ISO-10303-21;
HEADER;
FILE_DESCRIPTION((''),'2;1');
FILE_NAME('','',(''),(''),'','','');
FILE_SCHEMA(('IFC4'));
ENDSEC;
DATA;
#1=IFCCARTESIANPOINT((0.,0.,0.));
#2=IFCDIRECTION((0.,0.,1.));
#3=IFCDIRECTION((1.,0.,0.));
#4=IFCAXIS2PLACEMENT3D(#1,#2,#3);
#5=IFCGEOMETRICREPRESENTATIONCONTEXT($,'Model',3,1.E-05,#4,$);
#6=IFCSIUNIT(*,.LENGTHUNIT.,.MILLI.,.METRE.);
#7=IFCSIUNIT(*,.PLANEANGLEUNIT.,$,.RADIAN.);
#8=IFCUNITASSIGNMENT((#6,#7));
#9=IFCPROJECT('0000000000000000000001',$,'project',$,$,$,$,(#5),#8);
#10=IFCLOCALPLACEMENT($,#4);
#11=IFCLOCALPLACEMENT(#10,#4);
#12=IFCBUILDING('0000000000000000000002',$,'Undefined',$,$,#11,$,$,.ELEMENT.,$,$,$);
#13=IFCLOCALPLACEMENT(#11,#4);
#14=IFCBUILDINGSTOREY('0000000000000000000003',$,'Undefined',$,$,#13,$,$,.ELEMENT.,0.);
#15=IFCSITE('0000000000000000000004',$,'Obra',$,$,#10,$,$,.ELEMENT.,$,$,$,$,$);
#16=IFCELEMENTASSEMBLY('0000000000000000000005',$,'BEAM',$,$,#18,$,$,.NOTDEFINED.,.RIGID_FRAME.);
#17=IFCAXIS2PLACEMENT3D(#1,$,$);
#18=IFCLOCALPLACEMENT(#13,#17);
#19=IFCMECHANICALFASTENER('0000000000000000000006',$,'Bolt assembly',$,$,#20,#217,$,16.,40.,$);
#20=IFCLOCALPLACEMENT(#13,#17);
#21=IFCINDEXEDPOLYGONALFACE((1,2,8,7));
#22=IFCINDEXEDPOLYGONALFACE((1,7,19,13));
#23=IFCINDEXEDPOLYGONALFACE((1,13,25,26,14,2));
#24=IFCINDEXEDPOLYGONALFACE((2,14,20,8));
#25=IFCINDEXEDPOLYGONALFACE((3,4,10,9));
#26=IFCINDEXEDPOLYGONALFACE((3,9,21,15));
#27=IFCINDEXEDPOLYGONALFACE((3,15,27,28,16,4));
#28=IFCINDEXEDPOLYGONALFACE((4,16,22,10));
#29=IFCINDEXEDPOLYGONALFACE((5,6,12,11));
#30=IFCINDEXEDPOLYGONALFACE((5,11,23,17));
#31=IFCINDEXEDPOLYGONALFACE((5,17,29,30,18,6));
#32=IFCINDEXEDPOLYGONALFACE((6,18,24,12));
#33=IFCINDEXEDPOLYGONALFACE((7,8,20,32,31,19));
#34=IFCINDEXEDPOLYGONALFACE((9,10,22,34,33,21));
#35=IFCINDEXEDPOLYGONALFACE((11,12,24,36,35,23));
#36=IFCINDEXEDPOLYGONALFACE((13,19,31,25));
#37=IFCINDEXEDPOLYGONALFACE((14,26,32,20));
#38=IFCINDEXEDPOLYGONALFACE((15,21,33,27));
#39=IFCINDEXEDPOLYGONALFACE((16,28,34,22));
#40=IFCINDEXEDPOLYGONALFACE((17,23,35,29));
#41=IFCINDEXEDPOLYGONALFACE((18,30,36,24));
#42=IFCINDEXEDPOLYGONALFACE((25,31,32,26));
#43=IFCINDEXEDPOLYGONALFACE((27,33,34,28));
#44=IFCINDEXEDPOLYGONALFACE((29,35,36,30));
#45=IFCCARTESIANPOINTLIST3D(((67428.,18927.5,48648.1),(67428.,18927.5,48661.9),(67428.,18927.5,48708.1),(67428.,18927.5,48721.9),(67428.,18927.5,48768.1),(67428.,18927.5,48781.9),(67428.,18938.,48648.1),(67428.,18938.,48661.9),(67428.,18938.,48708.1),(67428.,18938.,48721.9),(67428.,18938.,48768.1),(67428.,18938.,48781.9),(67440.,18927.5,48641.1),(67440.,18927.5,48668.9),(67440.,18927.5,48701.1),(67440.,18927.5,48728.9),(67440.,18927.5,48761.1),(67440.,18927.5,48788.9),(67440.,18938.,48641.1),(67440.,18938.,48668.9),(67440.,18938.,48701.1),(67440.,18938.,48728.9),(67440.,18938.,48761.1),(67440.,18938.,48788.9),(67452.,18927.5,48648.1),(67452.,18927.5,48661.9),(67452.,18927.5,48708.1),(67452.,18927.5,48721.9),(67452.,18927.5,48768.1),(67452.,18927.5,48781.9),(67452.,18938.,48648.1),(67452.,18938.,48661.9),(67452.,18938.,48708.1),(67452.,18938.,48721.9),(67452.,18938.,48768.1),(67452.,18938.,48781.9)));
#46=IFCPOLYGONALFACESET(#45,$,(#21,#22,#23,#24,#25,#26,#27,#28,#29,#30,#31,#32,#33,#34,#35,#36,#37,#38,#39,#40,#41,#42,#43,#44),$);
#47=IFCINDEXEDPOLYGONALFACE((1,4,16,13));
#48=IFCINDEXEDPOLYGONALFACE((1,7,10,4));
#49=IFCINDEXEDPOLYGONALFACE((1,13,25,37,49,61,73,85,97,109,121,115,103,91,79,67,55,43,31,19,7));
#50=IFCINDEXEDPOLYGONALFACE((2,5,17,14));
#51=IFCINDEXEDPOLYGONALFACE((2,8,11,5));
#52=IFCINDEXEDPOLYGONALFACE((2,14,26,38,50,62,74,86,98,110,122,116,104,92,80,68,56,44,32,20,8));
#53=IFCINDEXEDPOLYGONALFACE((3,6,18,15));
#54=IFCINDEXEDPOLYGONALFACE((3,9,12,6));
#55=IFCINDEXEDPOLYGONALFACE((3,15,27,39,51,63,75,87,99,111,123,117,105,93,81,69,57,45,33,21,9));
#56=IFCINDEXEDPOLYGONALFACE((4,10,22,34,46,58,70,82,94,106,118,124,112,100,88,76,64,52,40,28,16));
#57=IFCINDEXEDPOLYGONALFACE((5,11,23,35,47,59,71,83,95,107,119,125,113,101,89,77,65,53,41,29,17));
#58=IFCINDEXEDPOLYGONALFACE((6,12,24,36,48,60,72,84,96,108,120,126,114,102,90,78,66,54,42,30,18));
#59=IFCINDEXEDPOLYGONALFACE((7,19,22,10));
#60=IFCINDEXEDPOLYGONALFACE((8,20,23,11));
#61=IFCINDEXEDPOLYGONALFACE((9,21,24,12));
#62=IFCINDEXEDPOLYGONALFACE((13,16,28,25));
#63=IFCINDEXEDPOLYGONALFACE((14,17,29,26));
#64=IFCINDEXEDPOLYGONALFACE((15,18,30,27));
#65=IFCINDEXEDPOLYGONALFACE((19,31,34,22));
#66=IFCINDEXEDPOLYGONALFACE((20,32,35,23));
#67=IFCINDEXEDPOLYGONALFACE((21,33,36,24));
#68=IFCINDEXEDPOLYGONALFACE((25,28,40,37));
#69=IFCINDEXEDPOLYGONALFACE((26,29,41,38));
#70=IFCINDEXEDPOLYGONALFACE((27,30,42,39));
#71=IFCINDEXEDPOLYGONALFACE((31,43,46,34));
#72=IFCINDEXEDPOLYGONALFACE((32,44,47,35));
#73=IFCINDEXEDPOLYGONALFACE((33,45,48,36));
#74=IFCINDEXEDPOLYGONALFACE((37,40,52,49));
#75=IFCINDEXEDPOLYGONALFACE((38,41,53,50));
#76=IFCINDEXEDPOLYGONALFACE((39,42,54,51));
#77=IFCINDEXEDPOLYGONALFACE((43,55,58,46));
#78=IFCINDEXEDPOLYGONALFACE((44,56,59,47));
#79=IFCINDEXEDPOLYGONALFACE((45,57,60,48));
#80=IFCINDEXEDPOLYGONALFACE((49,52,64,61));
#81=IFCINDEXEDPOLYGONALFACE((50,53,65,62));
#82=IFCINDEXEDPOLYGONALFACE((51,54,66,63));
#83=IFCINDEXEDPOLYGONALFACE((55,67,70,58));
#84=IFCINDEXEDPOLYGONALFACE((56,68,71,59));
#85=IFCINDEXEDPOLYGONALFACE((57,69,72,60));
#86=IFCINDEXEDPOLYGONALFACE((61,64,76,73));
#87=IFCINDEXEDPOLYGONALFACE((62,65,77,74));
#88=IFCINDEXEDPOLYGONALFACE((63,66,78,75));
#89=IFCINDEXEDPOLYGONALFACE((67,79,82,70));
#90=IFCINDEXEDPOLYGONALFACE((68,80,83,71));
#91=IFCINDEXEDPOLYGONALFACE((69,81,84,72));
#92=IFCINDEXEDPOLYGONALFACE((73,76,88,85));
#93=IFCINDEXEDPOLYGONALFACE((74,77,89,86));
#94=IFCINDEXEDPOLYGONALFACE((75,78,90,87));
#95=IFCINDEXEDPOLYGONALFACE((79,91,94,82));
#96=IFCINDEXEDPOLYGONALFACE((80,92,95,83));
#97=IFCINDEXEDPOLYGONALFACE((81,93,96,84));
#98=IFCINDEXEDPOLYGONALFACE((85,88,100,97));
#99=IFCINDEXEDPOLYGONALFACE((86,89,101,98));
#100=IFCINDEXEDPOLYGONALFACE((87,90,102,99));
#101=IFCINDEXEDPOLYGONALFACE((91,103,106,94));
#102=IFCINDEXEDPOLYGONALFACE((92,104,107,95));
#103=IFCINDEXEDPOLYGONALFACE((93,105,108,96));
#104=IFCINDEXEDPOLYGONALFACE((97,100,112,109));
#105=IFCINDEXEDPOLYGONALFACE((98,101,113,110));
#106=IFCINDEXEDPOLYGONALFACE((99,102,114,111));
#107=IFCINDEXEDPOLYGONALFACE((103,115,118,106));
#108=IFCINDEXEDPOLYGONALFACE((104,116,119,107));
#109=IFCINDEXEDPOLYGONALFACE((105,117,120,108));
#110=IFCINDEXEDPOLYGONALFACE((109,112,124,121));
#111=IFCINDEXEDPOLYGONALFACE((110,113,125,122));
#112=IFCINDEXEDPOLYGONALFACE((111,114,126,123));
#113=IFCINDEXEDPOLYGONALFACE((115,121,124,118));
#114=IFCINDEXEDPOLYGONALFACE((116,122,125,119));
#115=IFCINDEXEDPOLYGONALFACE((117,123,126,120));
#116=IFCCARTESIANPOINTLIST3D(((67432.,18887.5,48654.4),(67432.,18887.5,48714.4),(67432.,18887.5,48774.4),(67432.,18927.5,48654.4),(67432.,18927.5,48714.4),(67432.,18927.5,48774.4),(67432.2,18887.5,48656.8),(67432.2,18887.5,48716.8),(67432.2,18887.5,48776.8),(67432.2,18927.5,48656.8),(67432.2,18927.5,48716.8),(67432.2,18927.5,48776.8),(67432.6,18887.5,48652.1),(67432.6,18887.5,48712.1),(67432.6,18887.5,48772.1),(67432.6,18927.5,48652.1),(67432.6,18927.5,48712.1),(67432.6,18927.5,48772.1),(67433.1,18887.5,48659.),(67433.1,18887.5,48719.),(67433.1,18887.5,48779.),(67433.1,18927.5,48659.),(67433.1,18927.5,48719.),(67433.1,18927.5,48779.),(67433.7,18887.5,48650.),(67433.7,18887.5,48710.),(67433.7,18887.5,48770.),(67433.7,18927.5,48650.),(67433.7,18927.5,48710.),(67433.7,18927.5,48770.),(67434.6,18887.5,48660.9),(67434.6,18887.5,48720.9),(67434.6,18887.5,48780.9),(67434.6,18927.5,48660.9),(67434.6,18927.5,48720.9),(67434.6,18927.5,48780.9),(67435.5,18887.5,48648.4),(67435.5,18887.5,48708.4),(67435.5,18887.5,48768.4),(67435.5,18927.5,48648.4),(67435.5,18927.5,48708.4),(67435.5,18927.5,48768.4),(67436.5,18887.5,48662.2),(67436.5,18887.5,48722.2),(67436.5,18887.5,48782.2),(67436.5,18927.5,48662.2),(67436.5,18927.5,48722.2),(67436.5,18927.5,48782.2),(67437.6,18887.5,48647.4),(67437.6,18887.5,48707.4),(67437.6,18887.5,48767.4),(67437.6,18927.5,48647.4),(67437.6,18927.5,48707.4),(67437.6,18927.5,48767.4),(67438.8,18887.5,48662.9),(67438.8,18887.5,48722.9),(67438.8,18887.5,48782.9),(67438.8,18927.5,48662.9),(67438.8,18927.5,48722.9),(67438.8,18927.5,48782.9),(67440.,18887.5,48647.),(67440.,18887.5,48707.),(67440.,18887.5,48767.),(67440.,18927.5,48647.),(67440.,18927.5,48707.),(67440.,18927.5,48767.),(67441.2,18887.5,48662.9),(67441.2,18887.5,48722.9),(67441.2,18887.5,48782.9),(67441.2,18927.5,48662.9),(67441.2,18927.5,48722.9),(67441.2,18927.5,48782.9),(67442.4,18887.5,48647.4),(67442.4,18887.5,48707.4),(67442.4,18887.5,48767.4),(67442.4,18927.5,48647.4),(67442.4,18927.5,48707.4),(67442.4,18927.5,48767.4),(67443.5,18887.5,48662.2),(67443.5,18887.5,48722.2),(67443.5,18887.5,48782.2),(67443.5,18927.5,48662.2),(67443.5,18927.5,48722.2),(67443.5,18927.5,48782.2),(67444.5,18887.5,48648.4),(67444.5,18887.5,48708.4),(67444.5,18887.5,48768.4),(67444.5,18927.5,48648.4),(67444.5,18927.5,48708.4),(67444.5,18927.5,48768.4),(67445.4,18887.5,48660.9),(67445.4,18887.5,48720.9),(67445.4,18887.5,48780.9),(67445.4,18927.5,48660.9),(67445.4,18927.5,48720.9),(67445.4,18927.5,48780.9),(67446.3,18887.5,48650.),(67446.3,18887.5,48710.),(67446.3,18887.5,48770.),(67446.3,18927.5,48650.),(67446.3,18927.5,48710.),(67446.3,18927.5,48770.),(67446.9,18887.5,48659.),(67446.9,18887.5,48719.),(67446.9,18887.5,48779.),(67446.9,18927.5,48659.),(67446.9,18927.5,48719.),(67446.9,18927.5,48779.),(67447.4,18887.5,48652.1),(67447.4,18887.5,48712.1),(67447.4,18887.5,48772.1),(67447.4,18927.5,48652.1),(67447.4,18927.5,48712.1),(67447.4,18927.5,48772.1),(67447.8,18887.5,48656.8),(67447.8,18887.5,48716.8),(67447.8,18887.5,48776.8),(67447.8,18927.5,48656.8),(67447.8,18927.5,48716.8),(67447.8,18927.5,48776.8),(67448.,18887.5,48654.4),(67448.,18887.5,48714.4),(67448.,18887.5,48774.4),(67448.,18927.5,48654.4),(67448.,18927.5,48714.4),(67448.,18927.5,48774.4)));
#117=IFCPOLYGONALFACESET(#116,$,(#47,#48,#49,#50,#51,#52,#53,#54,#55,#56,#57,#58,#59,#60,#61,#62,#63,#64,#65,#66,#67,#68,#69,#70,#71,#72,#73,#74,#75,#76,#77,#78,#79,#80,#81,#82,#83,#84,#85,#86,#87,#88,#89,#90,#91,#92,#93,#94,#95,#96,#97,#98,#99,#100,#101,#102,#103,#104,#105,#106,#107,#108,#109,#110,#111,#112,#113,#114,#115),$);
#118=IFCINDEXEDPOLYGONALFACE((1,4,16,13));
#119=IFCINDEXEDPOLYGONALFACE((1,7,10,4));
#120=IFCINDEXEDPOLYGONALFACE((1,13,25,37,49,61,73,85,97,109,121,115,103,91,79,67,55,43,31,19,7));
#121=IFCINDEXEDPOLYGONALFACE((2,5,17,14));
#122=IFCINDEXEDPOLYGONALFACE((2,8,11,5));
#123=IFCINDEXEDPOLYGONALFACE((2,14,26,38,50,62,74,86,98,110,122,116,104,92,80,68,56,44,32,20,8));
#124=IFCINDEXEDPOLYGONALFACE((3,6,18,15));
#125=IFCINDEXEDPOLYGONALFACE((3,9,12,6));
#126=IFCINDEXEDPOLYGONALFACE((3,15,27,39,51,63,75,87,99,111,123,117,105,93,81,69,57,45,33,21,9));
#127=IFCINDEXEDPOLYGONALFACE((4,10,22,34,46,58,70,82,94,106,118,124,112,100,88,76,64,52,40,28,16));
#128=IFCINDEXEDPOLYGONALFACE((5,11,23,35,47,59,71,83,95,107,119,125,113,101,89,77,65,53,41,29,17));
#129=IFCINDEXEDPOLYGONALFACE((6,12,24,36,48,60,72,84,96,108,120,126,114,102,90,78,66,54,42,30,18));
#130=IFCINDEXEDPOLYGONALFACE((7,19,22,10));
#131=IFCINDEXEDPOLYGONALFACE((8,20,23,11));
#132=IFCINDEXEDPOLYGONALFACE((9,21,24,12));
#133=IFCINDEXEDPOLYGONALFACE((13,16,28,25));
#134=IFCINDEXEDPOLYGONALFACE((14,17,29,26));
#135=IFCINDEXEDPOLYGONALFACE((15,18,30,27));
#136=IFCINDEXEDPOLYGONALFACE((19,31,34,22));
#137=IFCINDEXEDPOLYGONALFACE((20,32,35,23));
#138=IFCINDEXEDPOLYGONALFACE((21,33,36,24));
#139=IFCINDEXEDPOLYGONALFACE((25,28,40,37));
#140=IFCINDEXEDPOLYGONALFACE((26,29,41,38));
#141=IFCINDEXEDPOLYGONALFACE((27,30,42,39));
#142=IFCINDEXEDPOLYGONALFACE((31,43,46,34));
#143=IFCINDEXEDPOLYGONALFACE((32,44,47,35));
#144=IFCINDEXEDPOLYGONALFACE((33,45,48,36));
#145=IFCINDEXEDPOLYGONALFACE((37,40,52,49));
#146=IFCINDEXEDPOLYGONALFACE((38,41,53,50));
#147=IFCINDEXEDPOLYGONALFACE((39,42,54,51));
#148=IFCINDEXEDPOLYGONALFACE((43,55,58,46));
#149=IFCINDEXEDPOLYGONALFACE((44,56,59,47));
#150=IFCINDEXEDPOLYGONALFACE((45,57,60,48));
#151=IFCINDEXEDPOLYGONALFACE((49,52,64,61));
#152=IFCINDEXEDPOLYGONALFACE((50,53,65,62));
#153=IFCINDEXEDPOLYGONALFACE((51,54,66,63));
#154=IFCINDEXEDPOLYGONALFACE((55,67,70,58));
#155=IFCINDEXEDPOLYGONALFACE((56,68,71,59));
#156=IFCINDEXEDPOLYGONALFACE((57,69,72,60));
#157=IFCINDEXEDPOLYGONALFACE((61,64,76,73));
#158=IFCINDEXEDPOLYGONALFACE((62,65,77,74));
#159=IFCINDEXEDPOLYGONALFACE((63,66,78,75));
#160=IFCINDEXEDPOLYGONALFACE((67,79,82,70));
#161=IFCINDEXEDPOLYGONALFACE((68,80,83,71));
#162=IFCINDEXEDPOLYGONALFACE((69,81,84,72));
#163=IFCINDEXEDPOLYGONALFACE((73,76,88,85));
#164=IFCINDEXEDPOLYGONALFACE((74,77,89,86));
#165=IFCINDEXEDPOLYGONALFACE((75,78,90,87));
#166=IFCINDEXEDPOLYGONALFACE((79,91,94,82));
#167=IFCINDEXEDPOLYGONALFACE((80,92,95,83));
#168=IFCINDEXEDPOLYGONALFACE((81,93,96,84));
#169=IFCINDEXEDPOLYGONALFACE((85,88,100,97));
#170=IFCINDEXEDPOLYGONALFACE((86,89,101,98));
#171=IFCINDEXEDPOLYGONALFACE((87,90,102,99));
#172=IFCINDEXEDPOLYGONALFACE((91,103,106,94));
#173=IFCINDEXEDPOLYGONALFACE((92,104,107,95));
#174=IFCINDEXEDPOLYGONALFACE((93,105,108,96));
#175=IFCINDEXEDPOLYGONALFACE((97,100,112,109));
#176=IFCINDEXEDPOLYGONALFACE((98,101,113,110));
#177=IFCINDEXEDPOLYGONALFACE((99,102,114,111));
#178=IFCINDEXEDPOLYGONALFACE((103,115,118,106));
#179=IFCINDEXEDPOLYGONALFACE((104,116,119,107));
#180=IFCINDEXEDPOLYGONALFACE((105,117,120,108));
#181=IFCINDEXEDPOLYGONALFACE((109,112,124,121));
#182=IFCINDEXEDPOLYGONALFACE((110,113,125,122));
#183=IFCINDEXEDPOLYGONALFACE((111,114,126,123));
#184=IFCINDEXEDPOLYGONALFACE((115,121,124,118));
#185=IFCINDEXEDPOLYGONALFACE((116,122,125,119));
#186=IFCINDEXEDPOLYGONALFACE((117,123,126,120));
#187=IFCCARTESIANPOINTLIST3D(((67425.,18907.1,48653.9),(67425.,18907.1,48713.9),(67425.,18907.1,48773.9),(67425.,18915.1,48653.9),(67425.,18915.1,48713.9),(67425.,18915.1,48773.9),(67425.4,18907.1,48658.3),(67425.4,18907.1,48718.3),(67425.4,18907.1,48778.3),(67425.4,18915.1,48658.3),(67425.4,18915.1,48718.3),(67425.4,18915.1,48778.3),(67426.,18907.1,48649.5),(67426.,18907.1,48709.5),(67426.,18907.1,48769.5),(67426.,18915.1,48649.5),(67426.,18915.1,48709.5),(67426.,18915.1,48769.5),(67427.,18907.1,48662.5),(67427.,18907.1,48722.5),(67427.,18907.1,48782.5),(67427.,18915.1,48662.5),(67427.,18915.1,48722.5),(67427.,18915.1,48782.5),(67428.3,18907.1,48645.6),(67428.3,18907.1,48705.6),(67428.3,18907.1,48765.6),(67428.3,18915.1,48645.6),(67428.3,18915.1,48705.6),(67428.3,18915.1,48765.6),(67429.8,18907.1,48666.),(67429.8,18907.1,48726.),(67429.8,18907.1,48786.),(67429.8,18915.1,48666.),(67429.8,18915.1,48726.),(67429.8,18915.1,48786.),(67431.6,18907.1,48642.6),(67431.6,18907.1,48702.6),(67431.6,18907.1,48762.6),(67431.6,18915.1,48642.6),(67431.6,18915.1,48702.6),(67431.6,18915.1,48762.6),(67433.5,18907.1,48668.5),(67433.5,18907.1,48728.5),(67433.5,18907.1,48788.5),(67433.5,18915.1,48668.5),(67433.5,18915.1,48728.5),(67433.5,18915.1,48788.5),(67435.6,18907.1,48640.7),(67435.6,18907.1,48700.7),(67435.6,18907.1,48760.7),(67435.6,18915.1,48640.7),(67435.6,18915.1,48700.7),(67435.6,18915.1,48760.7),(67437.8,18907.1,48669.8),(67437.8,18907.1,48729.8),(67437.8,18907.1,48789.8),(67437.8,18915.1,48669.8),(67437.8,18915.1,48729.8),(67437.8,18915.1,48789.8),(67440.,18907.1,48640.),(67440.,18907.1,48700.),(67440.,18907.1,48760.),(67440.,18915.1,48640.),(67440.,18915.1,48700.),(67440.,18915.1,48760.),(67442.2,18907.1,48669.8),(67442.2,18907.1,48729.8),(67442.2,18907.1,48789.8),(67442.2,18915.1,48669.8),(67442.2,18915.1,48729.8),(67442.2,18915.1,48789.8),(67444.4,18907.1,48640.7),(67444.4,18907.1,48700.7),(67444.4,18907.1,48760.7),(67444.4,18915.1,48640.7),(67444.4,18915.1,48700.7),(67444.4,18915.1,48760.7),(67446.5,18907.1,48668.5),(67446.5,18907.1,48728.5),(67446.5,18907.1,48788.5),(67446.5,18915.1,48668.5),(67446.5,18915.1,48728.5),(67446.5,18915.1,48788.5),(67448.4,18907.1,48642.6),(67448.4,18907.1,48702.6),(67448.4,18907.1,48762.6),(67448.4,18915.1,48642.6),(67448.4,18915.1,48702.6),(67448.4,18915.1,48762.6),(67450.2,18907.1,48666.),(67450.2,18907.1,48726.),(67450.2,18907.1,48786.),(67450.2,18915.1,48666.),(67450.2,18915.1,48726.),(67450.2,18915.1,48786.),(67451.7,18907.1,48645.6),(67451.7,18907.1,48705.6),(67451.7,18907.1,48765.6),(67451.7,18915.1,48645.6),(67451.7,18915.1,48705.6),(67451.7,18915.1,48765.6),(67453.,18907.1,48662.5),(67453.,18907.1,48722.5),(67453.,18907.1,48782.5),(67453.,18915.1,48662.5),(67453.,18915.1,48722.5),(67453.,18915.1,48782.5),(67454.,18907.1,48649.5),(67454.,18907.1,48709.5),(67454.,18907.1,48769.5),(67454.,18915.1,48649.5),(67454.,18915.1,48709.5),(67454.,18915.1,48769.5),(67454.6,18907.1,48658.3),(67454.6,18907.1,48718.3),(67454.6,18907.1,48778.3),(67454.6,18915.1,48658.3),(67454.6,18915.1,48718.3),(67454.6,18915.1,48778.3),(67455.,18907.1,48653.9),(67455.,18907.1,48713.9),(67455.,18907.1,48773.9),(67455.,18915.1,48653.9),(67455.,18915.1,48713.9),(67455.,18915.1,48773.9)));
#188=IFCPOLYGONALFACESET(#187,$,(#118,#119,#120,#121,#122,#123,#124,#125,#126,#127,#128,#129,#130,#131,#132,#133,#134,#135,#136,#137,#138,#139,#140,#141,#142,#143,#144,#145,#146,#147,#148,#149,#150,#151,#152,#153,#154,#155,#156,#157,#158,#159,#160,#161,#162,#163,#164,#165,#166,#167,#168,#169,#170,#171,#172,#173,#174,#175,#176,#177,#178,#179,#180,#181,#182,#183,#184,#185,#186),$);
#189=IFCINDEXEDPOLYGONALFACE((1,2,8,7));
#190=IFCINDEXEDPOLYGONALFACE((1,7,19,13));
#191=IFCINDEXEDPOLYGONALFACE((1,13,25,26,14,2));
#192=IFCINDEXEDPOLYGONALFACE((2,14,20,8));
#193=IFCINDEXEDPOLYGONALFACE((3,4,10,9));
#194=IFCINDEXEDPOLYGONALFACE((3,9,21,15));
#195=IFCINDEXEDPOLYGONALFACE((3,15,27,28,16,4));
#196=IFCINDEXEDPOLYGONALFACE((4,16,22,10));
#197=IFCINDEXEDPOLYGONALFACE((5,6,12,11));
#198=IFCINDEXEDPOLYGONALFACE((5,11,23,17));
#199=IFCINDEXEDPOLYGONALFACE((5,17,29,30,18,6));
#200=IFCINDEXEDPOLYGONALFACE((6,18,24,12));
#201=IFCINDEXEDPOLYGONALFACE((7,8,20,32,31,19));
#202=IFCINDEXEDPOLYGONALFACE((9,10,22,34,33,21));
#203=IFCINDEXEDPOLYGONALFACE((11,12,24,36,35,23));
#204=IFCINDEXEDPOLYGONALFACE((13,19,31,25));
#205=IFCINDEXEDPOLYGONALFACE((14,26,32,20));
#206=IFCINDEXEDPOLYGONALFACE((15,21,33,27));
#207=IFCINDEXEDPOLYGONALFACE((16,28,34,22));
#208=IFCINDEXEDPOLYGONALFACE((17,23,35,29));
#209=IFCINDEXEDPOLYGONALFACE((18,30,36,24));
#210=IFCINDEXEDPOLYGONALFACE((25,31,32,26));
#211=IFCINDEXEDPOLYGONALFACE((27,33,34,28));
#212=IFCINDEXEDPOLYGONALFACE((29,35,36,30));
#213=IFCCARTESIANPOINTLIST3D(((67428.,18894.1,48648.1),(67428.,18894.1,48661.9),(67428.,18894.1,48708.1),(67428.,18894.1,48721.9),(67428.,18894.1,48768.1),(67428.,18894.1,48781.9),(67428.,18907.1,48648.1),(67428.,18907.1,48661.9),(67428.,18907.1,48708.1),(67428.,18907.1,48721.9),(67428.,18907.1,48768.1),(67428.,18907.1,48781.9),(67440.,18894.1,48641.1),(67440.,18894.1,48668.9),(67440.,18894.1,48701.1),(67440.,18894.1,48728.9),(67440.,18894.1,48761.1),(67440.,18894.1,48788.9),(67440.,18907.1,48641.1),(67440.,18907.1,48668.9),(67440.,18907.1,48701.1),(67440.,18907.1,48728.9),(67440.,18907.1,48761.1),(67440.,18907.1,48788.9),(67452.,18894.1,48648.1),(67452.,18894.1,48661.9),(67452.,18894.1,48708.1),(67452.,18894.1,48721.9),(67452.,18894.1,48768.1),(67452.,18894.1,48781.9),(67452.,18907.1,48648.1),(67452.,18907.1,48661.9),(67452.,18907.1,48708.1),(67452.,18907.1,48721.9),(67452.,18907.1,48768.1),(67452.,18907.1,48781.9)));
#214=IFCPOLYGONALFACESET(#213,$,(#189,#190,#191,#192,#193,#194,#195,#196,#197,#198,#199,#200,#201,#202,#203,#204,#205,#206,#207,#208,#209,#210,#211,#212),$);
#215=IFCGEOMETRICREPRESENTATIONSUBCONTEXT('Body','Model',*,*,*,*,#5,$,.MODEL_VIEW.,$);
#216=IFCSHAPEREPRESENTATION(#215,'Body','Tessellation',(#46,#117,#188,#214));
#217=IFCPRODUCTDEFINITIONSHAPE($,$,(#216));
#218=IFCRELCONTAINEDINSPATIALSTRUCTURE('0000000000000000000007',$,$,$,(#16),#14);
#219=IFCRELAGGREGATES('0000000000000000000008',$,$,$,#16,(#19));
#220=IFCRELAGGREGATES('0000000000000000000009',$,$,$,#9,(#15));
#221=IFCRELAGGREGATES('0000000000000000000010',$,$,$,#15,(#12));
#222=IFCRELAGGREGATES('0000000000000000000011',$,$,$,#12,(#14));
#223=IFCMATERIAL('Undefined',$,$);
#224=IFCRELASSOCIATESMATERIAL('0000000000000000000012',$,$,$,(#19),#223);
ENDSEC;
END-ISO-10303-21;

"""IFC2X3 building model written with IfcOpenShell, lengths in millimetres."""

from ifc_helpers import new_model, si_unit, frame, origin_with_axes, origin_2d_with_axis, place, context, subcontext, project, spatial, polyline, circle, outline, extrude, source, transform, mapped, material, element, aggregate, save


model = new_model("IFC2X3")

# Units and contexts
model_context = context("Model", 3, precision=1e-05, world=origin_with_axes())
body_context = subcontext(model_context, "Body", "Model", "MODEL_VIEW")
ifc_project = project(units=[si_unit("LENGTHUNIT", "METRE", prefix="MILLI"), si_unit("PLANEANGLEUNIT", "RADIAN")], contexts=[model_context])

# Site, building, storey
site_placement = place(None, origin_with_axes())
site = spatial("IfcSite", under=ifc_project, at=site_placement, Name="Obra", CompositionType="ELEMENT")
building_placement = place(site_placement, origin_with_axes())
building = spatial("IfcBuilding", under=site, at=building_placement, Name="Undefined", CompositionType="ELEMENT")
storey_placement = place(building_placement, origin_with_axes())
storey = spatial("IfcBuildingStorey", under=building, at=storey_placement, Name="Undefined", CompositionType="ELEMENT", Elevation=0.0)

# Element assembly, mechanical fastener
ifc_material_1 = material(Name="Undefined")
shared_shape_1 = source(origin_with_axes(), body_context, "Body", "SweptSolid", [
    extrude(outline(polyline([(13.9, 0.0), (6.9, 12.0), (-6.9, 12.0), (-13.9, 0.0), (-6.9, -12.0), (6.9, -12.0), (13.9, 0.0)])), frame((0.0, -19.7, 0.0), z_axis=(0.0, 1.0, 0.0), x_axis=(1.0, 0.0, 0.0)), (0.0, 0.0, 1.0), 10.6),
    extrude(circle(Radius=8.0, at=origin_2d_with_axis()), frame((0.0, -9.1, 0.0), z_axis=(0.0, 1.0, 0.0), x_axis=(1.0, 0.0, 0.0)), (0.0, 0.0, 1.0), 40.0),
    extrude(circle(Radius=15.0, at=origin_2d_with_axis()), frame((0.0, 3.3, 0.0), z_axis=(0.0, 1.0, 0.0), x_axis=(1.0, 0.0, 0.0)), (0.0, 0.0, 1.0), 8.0),
    extrude(outline(polyline([(13.9, 0.0), (6.9, 12.0), (-6.9, 12.0), (-13.9, 0.0), (-6.9, -12.0), (6.9, -12.0), (13.9, 0.0)])), frame((0.0, 11.3, 0.0), z_axis=(0.0, 1.0, 0.0), x_axis=(1.0, 0.0, 0.0)), (0.0, 0.0, 1.0), 13.0),
])
assembly_1_placement = place(storey_placement, origin_with_axes())
assembly_1 = element("IfcElementAssembly", 1, at=assembly_1_placement, inside=storey, Name="BEAM", AssemblyPlace="NOTDEFINED", PredefinedType="RIGID_FRAME")
mechanical_fastener_1_placement = place(assembly_1_placement, frame((67490.0, 18918.4, 48835.0), z_axis=(-1.0, 0.0, 0.0), x_axis=(0.0, 0.0, -1.0)))
mechanical_fastener_1 = element("IfcMechanicalFastener", 2, at=mechanical_fastener_1_placement, material=ifc_material_1, Name="Bolt assembly", NominalDiameter=16.0, NominalLength=40.0, context=body_context, shape_type="MappedRepresentation", body=[
    mapped(shared_shape_1, transform((60.0, 0.0, 50.0))),
    mapped(shared_shape_1, transform((120.0, 0.0, 50.0))),
    mapped(shared_shape_1, transform((180.0, 0.0, 50.0))),
])
aggregate(assembly_1, [mechanical_fastener_1])

save(model, "model.ifc")
